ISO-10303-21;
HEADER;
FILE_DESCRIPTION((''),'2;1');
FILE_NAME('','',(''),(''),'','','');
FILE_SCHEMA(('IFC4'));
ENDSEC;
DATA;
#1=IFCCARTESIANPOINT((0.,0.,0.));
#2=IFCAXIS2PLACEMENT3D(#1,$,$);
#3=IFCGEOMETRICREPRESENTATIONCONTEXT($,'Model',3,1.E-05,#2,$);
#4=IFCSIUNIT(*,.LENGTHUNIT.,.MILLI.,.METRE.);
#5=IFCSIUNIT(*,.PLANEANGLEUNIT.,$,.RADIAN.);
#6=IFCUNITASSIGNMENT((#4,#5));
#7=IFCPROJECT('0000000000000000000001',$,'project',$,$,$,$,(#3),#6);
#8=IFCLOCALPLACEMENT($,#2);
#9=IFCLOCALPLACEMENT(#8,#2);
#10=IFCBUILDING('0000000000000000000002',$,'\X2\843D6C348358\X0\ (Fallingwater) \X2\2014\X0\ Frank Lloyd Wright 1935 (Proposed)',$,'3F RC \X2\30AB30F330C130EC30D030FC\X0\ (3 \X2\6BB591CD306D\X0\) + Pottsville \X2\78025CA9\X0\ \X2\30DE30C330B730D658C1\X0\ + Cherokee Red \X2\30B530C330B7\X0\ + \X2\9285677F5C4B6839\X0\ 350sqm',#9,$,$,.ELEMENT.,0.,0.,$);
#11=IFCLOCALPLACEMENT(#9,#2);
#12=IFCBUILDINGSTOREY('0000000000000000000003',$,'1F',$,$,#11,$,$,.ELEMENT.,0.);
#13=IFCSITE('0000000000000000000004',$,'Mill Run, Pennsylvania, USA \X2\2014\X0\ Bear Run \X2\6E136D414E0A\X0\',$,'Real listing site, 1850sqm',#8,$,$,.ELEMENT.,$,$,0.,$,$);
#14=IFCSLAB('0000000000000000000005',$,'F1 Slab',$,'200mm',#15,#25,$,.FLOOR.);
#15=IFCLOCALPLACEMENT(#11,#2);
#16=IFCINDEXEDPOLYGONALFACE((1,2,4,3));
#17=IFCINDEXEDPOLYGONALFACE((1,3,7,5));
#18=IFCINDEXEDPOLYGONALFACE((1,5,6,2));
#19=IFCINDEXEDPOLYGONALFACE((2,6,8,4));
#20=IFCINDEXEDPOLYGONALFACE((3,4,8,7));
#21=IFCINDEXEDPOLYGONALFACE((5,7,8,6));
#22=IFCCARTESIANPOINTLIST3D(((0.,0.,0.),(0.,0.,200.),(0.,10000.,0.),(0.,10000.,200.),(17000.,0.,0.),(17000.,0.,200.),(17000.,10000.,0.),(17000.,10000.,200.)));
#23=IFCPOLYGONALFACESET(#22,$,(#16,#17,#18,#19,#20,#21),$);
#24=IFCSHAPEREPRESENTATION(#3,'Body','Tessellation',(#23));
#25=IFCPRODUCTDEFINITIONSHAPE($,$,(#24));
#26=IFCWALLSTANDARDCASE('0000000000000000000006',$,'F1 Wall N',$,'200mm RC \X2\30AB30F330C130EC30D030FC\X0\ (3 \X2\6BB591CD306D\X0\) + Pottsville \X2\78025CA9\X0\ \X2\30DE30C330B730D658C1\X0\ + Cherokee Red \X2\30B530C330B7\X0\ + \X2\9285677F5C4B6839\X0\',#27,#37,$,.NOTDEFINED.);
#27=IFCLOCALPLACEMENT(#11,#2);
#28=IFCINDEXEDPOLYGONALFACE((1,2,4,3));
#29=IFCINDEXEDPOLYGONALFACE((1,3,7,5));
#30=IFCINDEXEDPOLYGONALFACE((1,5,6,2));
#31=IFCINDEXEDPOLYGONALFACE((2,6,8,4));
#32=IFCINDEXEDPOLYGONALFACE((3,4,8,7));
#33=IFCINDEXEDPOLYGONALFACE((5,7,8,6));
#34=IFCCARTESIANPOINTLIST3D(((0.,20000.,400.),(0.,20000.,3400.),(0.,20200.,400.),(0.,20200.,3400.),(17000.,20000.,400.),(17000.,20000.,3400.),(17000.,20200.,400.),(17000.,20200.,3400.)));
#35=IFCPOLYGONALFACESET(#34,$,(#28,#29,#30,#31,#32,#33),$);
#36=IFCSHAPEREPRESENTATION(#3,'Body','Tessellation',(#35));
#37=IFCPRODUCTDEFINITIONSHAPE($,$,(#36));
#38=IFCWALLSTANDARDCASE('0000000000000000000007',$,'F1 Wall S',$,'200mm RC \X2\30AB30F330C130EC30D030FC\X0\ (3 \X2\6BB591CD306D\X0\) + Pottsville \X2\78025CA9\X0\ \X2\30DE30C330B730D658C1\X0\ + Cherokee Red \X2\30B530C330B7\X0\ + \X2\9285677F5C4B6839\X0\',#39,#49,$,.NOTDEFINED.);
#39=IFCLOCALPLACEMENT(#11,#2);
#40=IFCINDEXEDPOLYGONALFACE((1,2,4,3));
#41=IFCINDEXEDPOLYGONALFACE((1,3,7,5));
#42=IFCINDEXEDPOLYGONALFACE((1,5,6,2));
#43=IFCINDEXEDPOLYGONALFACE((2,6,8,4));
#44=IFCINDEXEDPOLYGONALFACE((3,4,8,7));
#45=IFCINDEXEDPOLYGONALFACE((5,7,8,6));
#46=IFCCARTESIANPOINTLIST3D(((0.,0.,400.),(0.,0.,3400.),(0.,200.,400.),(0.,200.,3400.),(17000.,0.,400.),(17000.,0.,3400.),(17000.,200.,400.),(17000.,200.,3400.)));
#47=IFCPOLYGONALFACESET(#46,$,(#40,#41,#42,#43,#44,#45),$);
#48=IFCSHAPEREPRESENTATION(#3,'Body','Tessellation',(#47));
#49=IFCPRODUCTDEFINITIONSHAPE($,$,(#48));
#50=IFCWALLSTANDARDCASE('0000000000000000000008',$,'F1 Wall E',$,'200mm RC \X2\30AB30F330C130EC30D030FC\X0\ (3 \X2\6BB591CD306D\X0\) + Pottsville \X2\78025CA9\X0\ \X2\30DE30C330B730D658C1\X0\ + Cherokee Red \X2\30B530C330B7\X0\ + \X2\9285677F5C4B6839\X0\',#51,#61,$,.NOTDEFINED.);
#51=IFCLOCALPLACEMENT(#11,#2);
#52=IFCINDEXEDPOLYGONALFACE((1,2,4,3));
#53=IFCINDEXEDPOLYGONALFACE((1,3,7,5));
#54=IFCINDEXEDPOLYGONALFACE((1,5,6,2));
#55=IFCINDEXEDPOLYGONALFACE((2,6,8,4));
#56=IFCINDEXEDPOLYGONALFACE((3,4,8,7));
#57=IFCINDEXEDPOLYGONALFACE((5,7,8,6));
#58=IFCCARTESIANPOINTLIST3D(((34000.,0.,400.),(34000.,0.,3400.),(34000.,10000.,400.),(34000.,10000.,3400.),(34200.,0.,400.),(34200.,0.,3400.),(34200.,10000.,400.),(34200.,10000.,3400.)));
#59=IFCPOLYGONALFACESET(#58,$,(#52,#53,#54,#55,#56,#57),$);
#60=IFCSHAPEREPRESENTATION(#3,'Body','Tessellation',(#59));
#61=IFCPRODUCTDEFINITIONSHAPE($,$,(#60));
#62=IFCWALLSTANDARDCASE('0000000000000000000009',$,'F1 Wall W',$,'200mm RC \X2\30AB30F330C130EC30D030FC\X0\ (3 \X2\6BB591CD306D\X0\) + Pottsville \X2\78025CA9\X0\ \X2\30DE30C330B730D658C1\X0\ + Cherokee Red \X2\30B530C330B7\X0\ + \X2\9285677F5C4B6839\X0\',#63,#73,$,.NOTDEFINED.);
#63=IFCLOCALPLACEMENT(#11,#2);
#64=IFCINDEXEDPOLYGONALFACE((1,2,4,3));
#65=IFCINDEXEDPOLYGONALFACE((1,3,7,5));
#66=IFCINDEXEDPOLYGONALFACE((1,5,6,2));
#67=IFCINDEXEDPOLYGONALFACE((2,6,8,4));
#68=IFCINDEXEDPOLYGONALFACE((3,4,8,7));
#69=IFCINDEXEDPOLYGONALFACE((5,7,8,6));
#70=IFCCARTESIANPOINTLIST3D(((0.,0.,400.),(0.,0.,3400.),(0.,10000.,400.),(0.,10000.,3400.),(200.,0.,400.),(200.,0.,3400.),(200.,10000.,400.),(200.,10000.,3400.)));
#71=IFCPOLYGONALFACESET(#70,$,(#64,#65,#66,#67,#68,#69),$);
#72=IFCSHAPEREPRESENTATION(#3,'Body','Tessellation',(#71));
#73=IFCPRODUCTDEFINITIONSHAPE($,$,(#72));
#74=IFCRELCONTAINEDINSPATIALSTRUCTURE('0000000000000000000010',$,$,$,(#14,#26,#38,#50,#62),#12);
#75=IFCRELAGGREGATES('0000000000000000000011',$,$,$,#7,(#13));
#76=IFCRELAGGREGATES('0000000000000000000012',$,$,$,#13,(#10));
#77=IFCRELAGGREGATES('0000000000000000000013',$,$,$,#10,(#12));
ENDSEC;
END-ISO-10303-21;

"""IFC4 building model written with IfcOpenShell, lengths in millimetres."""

from ifc_helpers import new_model, si_unit, frame, frame_2d, origin, place, context, project, spatial, rectangle, extrude, element, save


model = new_model("IFC4")

# Units and contexts
model_context = context("Model", 3, precision=1e-05, world=origin())
ifc_project = project(units=[si_unit("LENGTHUNIT", "METRE", prefix="MILLI"), si_unit("PLANEANGLEUNIT", "RADIAN")], contexts=[model_context])

# Site, building, storey
site_placement = place(None, origin())
site = spatial("IfcSite", under=ifc_project, at=site_placement, Name="Mill Run, Pennsylvania, USA — Bear Run 渓流上", ObjectType="Real listing site, 1850sqm", CompositionType="ELEMENT", RefElevation=0.0)
building_placement = place(site_placement, origin())
building = spatial("IfcBuilding", under=site, at=building_placement, Name="落水荘 (Fallingwater) — Frank Lloyd Wright 1935 (Proposed)", ObjectType="3F RC カンチレバー (3 段重ね) + Pottsville 砂岩 マッシブ壁 + Cherokee Red サッシ + 銅板屋根 350sqm", CompositionType="ELEMENT", ElevationOfRefHeight=0.0, ElevationOfTerrain=0.0)
storey_placement = place(building_placement, origin())
storey = spatial("IfcBuildingStorey", under=building, at=storey_placement, Name="1F", CompositionType="ELEMENT", Elevation=0.0)

# Slab
slab_placement = place(storey_placement, origin())
element("IfcSlab", 1, at=slab_placement, inside=storey, Name="F1 Slab", ObjectType="200mm", PredefinedType="FLOOR", context=model_context, shape_type="SweptSolid", body=[
    extrude(rectangle(XDim=17000.0, YDim=10000.0, at=frame_2d((8500.0, 5000.0))), origin(), (0.0, 0.0, 1.0), 200.0),
])

# Walls
wall_1_placement = place(storey_placement, frame((0.0, 10000.0, 200.0)))
element("IfcWallStandardCase", 2, at=wall_1_placement, inside=storey, Name="F1 Wall N", ObjectType="200mm RC カンチレバー (3 段重ね) + Pottsville 砂岩 マッシブ壁 + Cherokee Red サッシ + 銅板屋根", PredefinedType="NOTDEFINED", context=model_context, shape_type="SweptSolid", body=[
    extrude(rectangle(XDim=17000.0, YDim=200.0, at=frame_2d((8500.0, 100.0))), frame((0.0, 10000.0, 200.0)), (0.0, 0.0, 1.0), 3000.0),
])
wall_2_placement = place(storey_placement, frame((0.0, 0.0, 200.0)))
element("IfcWallStandardCase", 3, at=wall_2_placement, inside=storey, Name="F1 Wall S", ObjectType="200mm RC カンチレバー (3 段重ね) + Pottsville 砂岩 マッシブ壁 + Cherokee Red サッシ + 銅板屋根", PredefinedType="NOTDEFINED", context=model_context, shape_type="SweptSolid", body=[
    extrude(rectangle(XDim=17000.0, YDim=200.0, at=frame_2d((8500.0, 100.0))), frame((0.0, 0.0, 200.0)), (0.0, 0.0, 1.0), 3000.0),
])
wall_3_placement = place(storey_placement, frame((17000.0, 0.0, 200.0)))
element("IfcWallStandardCase", 4, at=wall_3_placement, inside=storey, Name="F1 Wall E", ObjectType="200mm RC カンチレバー (3 段重ね) + Pottsville 砂岩 マッシブ壁 + Cherokee Red サッシ + 銅板屋根", PredefinedType="NOTDEFINED", context=model_context, shape_type="SweptSolid", body=[
    extrude(rectangle(XDim=200.0, YDim=10000.0, at=frame_2d((100.0, 5000.0))), frame((17000.0, 0.0, 200.0)), (0.0, 0.0, 1.0), 3000.0),
])
wall_4_placement = place(storey_placement, frame((0.0, 0.0, 200.0)))
element("IfcWallStandardCase", 5, at=wall_4_placement, inside=storey, Name="F1 Wall W", ObjectType="200mm RC カンチレバー (3 段重ね) + Pottsville 砂岩 マッシブ壁 + Cherokee Red サッシ + 銅板屋根", PredefinedType="NOTDEFINED", context=model_context, shape_type="SweptSolid", body=[
    extrude(rectangle(XDim=200.0, YDim=10000.0, at=frame_2d((100.0, 5000.0))), frame((0.0, 0.0, 200.0)), (0.0, 0.0, 1.0), 3000.0),
])

save(model, "model.ifc")
